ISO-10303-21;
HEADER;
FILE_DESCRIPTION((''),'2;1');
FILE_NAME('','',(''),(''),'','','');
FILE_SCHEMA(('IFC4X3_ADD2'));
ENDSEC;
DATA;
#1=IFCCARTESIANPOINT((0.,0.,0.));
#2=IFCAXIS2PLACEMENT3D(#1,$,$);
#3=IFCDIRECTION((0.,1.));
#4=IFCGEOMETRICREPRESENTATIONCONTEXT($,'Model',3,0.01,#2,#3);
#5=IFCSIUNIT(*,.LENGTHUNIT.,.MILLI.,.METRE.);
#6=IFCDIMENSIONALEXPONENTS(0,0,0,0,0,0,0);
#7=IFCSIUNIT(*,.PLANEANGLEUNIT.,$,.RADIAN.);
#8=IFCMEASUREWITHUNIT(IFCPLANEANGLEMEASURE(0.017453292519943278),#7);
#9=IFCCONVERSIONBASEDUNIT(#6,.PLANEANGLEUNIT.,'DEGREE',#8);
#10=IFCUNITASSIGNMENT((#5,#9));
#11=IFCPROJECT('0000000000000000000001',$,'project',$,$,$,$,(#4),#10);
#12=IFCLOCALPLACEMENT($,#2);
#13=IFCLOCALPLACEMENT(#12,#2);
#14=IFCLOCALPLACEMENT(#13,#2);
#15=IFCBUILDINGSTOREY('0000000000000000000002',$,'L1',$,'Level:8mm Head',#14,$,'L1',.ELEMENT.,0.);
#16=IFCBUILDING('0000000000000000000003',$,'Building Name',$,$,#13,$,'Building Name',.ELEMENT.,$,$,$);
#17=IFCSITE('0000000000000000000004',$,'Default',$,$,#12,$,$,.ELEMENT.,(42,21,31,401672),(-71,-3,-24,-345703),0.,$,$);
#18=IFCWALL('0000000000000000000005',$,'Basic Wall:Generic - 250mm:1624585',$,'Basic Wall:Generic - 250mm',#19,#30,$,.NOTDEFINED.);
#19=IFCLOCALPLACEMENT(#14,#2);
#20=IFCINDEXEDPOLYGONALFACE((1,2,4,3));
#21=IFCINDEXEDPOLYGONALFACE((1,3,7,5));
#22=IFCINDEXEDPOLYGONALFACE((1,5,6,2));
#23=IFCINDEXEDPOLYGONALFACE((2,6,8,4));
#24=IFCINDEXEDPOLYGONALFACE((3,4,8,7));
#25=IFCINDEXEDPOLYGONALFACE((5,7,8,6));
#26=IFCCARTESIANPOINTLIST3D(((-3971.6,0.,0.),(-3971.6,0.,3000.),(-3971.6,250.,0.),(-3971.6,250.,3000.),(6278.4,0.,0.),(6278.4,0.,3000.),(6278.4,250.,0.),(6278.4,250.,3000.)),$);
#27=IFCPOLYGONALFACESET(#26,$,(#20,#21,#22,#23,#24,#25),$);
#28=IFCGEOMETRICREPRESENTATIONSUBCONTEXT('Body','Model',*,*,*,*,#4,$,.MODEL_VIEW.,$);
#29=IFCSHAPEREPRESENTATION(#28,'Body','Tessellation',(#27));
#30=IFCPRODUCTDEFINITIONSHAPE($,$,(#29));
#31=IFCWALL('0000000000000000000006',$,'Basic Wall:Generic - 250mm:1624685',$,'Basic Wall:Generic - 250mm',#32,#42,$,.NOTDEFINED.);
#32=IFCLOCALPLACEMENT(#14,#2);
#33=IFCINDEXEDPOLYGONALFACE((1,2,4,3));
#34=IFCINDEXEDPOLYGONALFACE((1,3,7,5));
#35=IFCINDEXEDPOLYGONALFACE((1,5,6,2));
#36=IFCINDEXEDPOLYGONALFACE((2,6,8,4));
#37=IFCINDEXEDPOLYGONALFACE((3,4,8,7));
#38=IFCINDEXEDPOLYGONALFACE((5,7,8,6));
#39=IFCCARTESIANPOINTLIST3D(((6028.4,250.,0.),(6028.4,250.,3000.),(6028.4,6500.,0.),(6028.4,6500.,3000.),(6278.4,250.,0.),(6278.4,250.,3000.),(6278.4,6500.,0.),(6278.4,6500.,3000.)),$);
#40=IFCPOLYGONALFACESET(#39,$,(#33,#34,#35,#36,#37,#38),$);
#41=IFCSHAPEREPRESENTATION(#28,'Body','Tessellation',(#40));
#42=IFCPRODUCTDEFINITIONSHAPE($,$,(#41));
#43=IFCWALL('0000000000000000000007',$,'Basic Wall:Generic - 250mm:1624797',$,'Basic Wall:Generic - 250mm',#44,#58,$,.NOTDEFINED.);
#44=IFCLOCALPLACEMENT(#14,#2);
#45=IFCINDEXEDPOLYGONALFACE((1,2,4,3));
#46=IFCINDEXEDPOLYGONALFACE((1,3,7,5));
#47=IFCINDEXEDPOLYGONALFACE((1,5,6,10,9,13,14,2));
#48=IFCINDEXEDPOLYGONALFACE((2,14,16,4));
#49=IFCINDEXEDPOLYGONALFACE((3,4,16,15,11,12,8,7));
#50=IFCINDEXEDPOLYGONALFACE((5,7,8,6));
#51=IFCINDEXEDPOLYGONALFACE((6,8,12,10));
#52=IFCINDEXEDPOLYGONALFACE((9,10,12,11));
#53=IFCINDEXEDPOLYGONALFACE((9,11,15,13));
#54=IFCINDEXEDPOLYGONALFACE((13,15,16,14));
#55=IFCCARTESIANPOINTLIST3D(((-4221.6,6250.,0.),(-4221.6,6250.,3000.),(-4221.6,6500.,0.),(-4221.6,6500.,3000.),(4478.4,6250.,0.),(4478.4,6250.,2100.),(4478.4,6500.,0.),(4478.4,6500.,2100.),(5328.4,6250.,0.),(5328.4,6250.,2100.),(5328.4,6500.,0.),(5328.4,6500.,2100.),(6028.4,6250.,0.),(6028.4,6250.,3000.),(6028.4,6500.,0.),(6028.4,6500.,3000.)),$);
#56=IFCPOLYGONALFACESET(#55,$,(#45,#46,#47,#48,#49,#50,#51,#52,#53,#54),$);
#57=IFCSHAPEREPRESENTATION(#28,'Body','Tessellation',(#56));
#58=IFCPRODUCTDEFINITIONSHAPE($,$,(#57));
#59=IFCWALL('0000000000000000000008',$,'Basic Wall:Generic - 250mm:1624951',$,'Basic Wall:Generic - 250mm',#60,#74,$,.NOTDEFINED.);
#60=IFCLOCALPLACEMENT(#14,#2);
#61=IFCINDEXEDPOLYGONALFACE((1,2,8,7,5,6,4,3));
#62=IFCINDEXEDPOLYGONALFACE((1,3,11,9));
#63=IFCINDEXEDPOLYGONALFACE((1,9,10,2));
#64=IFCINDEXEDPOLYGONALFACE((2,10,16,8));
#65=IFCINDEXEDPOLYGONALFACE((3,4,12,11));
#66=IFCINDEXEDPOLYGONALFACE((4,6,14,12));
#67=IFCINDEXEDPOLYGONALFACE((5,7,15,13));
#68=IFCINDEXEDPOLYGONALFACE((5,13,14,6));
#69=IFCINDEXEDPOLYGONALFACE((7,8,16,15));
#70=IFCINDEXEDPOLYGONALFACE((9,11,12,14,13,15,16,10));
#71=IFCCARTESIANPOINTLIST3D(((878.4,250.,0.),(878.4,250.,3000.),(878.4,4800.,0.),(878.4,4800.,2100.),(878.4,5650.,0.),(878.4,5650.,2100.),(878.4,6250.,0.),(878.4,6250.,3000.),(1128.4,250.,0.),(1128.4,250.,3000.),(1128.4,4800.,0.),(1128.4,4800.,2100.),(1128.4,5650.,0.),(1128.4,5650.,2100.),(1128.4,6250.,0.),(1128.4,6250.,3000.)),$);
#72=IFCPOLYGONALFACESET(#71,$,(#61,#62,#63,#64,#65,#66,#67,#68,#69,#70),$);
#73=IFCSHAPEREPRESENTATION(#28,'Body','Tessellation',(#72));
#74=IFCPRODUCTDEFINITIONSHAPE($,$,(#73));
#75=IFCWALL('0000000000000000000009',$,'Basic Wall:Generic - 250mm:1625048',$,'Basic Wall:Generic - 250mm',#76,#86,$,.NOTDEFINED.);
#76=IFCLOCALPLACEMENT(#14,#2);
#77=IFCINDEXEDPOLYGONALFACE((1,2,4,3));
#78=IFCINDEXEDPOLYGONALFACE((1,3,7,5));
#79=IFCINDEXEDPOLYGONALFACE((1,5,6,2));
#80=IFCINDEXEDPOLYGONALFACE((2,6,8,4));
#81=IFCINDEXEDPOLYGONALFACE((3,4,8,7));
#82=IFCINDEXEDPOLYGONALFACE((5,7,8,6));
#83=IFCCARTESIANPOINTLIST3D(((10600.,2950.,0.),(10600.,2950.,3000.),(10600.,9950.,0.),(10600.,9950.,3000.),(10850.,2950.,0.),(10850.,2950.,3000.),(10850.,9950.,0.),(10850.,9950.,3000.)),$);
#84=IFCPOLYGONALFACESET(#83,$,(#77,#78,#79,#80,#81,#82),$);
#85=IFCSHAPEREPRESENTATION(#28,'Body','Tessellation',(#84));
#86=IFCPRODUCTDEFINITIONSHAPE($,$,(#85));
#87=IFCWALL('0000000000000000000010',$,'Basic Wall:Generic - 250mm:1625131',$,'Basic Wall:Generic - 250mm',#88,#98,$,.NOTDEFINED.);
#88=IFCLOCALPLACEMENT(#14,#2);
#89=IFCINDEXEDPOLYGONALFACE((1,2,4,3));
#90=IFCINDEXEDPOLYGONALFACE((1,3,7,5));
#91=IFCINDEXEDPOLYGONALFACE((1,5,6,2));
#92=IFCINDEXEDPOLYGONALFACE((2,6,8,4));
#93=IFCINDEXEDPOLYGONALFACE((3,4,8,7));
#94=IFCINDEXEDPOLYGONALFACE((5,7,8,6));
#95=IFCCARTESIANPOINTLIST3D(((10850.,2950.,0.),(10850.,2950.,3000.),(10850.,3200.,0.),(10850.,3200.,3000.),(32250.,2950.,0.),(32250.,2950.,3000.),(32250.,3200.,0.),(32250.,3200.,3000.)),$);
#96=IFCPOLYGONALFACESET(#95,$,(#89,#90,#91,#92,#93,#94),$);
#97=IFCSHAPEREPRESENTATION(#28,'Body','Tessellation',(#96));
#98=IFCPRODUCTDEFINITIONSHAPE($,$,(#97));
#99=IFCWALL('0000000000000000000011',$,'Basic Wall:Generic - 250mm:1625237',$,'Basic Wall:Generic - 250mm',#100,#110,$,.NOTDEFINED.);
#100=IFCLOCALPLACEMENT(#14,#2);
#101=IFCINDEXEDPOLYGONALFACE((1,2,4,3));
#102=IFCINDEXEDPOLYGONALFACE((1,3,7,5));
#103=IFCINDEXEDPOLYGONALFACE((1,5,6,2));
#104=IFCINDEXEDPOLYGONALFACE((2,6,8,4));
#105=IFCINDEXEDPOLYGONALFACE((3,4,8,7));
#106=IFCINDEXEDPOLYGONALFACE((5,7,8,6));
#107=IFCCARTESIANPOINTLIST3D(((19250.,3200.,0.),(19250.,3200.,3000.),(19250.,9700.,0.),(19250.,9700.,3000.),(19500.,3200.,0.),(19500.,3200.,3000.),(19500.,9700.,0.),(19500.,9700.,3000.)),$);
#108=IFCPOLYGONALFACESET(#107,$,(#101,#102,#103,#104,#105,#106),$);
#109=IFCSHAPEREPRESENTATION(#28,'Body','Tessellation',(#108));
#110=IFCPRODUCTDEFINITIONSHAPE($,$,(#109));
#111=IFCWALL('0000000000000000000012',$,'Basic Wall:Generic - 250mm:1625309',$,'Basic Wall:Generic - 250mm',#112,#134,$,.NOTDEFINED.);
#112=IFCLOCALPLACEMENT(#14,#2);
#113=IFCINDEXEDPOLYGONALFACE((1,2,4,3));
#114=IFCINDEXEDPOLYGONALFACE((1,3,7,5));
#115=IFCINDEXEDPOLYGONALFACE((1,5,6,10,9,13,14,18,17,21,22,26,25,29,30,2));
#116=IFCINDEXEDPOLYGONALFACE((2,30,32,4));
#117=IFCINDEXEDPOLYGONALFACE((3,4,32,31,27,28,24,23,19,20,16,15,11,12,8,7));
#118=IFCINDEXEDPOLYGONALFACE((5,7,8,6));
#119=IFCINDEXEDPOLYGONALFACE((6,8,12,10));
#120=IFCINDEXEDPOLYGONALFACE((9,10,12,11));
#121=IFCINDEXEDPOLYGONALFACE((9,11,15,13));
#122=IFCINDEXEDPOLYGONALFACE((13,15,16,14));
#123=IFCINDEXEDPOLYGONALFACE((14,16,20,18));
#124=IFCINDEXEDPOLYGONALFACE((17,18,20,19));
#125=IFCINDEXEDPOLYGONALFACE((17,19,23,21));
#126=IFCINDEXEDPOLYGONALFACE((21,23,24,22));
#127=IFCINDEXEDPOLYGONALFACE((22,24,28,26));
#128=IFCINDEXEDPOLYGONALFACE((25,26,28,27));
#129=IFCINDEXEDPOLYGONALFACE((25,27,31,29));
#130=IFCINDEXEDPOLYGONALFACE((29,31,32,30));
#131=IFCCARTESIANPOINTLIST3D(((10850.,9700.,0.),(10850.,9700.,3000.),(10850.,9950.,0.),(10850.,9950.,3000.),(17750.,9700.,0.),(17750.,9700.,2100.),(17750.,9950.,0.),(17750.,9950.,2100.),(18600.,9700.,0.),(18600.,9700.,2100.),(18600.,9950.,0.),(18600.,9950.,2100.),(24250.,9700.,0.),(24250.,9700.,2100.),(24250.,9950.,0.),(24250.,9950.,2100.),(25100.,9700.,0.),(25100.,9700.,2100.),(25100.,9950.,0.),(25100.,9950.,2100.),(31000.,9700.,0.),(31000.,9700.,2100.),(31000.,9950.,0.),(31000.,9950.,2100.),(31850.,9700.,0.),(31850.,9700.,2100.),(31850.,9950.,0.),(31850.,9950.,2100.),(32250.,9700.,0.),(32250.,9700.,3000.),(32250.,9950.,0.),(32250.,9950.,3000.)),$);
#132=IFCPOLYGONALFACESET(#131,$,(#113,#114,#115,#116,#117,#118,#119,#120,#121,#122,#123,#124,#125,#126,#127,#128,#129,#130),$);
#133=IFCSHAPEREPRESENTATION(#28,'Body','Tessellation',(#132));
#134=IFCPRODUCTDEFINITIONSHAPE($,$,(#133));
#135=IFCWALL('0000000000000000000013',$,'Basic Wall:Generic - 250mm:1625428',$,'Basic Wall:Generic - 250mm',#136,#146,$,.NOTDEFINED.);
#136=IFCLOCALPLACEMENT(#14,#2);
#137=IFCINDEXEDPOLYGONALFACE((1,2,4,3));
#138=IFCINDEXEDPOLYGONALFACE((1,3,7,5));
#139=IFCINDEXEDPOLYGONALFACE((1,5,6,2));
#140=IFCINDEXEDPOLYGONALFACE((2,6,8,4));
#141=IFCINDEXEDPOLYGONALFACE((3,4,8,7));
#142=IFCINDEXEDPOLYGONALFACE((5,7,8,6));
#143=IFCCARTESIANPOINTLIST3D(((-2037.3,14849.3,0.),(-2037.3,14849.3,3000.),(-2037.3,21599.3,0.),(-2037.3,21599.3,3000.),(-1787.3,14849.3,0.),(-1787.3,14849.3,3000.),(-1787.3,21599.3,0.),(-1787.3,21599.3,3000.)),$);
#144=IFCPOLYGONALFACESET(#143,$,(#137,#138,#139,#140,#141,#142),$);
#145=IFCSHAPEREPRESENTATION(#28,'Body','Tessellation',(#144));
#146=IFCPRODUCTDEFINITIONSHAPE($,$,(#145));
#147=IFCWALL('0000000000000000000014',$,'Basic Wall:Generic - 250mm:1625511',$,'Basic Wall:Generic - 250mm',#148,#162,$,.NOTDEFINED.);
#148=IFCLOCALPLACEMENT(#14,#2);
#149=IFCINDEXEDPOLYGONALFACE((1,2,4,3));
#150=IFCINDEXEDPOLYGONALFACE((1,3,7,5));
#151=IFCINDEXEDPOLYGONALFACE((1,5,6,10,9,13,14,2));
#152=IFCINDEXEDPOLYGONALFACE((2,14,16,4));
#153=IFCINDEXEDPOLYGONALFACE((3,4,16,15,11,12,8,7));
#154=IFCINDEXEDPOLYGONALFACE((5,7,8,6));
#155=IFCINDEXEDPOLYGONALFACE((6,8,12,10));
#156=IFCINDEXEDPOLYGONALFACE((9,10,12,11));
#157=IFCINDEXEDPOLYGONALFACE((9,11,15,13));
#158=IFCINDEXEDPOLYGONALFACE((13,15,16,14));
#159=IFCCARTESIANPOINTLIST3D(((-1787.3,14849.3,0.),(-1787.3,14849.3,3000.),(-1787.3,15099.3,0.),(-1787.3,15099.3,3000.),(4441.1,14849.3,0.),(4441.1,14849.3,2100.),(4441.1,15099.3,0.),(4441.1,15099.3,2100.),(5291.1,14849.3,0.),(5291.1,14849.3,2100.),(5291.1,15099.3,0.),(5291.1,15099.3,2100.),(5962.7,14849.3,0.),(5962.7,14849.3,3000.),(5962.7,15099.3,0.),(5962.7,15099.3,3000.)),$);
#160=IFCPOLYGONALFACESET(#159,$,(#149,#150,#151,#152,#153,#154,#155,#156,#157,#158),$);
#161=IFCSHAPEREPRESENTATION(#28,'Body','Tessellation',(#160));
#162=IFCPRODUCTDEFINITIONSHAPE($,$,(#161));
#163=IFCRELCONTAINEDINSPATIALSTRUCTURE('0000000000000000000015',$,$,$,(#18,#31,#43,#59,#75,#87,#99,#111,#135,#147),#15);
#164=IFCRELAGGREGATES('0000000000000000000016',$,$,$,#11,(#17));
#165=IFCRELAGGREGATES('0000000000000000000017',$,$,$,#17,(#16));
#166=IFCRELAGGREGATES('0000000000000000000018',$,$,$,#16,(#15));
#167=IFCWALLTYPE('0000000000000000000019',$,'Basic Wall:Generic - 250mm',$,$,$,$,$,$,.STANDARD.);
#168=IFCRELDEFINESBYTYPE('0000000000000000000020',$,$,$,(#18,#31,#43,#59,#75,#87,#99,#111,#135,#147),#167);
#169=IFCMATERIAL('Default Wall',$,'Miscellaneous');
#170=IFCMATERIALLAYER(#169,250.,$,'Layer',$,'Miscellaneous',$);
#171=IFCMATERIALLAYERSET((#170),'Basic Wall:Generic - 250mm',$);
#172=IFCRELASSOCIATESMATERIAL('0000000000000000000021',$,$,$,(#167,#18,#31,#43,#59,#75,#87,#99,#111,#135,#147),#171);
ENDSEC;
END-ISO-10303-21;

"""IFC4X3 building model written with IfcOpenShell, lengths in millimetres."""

from ifc_helpers import new_model, entity, si_unit, converted_unit, direction, frame, frame_2d, origin, place, context, subcontext, project, spatial, rectangle, extrude, material, layer, layer_set, type_object, element, save


model = new_model("IFC4X3")

# Units and contexts
model_context = context("Model", 3, precision=0.01, world=origin(), true_north=direction((0.0, 1.0)))
body_context = subcontext(model_context, "Body", "Model", "MODEL_VIEW")
ifc_project = project(units=[si_unit("LENGTHUNIT", "METRE", prefix="MILLI"), converted_unit("PLANEANGLEUNIT", "DEGREE", entity("IfcPlaneAngleMeasure", 0.017453292519943278), si_unit("PLANEANGLEUNIT", "RADIAN"), dimensions=[0, 0, 0, 0, 0, 0, 0])], contexts=[model_context])

# Site, building, storey
site_placement = place(None, origin())
site = spatial("IfcSite", under=ifc_project, at=site_placement, Name="Default", CompositionType="ELEMENT", RefLatitude=(42, 21, 31, 401672), RefLongitude=(-71, -3, -24, -345703), RefElevation=0.0)
building_placement = place(site_placement, origin())
building = spatial("IfcBuilding", under=site, at=building_placement, Name="Building Name", LongName="Building Name", CompositionType="ELEMENT")
storey_placement = place(building_placement, origin())
storey = spatial("IfcBuildingStorey", under=building, at=storey_placement, Name="L1", ObjectType="Level:8mm Head", LongName="L1", CompositionType="ELEMENT", Elevation=0.0)

# Walls
ifc_material = material(Name="Default Wall", Category="Miscellaneous")
ifc_layer = layer(ifc_material, 250.0, Name="Layer", Category="Miscellaneous")
ifc_layer_set = layer_set([ifc_layer], Name="Basic Wall:Generic - 250mm")
wall_type = type_object("IfcWallType", Name="Basic Wall:Generic - 250mm", PredefinedType="STANDARD", material=ifc_layer_set)
wall_1_placement = place(storey_placement, frame((-3971.6, 125.0, 0.0)))
element("IfcWall", 1, at=wall_1_placement, inside=storey, type_object=wall_type, material=ifc_layer_set, Name="Basic Wall:Generic - 250mm:1624585", ObjectType="Basic Wall:Generic - 250mm", PredefinedType="NOTDEFINED", context=body_context, shape_type="SweptSolid", body=[
    extrude(rectangle(XDim=10250.0, YDim=250.0, at=frame_2d((5125.0, 0.0), x_axis=(-1.0, 0.0))), origin(), (0.0, 0.0, 1.0), 3000.0),
])
wall_2_placement = place(storey_placement, frame((6153.4, 250.0, 0.0), z_axis=(0.0, 0.0, 1.0), x_axis=(0.0, 1.0, 0.0)))
element("IfcWall", 2, at=wall_2_placement, inside=storey, type_object=wall_type, material=ifc_layer_set, Name="Basic Wall:Generic - 250mm:1624685", ObjectType="Basic Wall:Generic - 250mm", PredefinedType="NOTDEFINED", context=body_context, shape_type="SweptSolid", body=[
    extrude(rectangle(XDim=6250.0, YDim=250.0, at=frame_2d((3125.0, 0.0), x_axis=(-1.0, 0.0))), origin(), (0.0, 0.0, 1.0), 3000.0),
])

# Walls, openings
wall_3_placement = place(storey_placement, frame((6028.4, 6375.0, 0.0), z_axis=(0.0, 0.0, 1.0), x_axis=(-1.0, 0.0, 0.0)))
wall_3 = element("IfcWall", 3, at=wall_3_placement, inside=storey, type_object=wall_type, material=ifc_layer_set, Name="Basic Wall:Generic - 250mm:1624797", ObjectType="Basic Wall:Generic - 250mm", PredefinedType="NOTDEFINED", context=body_context, shape_type="SweptSolid", body=[
    extrude(rectangle(XDim=10250.0, YDim=250.0, at=frame_2d((5125.0, 0.0), x_axis=(1.0, 0.0))), origin(), (0.0, 0.0, 1.0), 3000.0),
])
opening_1_placement = place(wall_3_placement, frame((700.0, -125.0, 0.0)))
element("IfcOpeningElement", 4, at=opening_1_placement, cuts=wall_3, PredefinedType="OPENING", context=body_context, shape_type="SweptSolid", body=[
    extrude(rectangle(XDim=2100.0, YDim=850.0, at=frame_2d((1050.0, 425.0), x_axis=(1.0, 0.0))), frame((0.0, 0.0, 0.0), z_axis=(0.0, 1.0, 0.0), x_axis=(0.0, 0.0, 1.0)), (0.0, 0.0, 1.0), 250.0),
])
wall_4_placement = place(storey_placement, frame((1003.4, 6250.0, 0.0), z_axis=(0.0, 0.0, 1.0), x_axis=(0.0, -1.0, 0.0)))
wall_4 = element("IfcWall", 5, at=wall_4_placement, inside=storey, type_object=wall_type, material=ifc_layer_set, Name="Basic Wall:Generic - 250mm:1624951", ObjectType="Basic Wall:Generic - 250mm", PredefinedType="NOTDEFINED", context=body_context, shape_type="SweptSolid", body=[
    extrude(rectangle(XDim=6000.0, YDim=250.0, at=frame_2d((3000.0, 0.0), x_axis=(1.0, 0.0))), origin(), (0.0, 0.0, 1.0), 3000.0),
])
opening_2_placement = place(wall_4_placement, frame((1450.0, 125.0, 0.0)))
element("IfcOpeningElement", 6, at=opening_2_placement, cuts=wall_4, PredefinedType="OPENING", context=body_context, shape_type="SweptSolid", body=[
    extrude(rectangle(XDim=2100.0, YDim=850.0, at=frame_2d((1050.0, 425.0), x_axis=(1.0, 0.0))), frame((0.0, 0.0, 0.0), z_axis=(0.0, -1.0, 0.0), x_axis=(0.0, 0.0, 1.0)), (0.0, 0.0, 1.0), 250.0),
])

# Walls
wall_5_placement = place(storey_placement, frame((10725.0, 9950.0, 0.0), z_axis=(0.0, 0.0, 1.0), x_axis=(0.0, -1.0, 0.0)))
element("IfcWall", 7, at=wall_5_placement, inside=storey, type_object=wall_type, material=ifc_layer_set, Name="Basic Wall:Generic - 250mm:1625048", ObjectType="Basic Wall:Generic - 250mm", PredefinedType="NOTDEFINED", context=body_context, shape_type="SweptSolid", body=[
    extrude(rectangle(XDim=7000.0, YDim=250.0, at=frame_2d((3500.0, 0.0), x_axis=(-1.0, 0.0))), origin(), (0.0, 0.0, 1.0), 3000.0),
])
wall_6_placement = place(storey_placement, frame((10850.0, 3075.0, 0.0)))
element("IfcWall", 8, at=wall_6_placement, inside=storey, type_object=wall_type, material=ifc_layer_set, Name="Basic Wall:Generic - 250mm:1625131", ObjectType="Basic Wall:Generic - 250mm", PredefinedType="NOTDEFINED", context=body_context, shape_type="SweptSolid", body=[
    extrude(rectangle(XDim=21400.0, YDim=250.0, at=frame_2d((10700.0, 0.0), x_axis=(-1.0, 0.0))), origin(), (0.0, 0.0, 1.0), 3000.0),
])
wall_7_placement = place(storey_placement, frame((19375.0, 3200.0, 0.0), z_axis=(0.0, 0.0, 1.0), x_axis=(0.0, 1.0, 0.0)))
element("IfcWall", 9, at=wall_7_placement, inside=storey, type_object=wall_type, material=ifc_layer_set, Name="Basic Wall:Generic - 250mm:1625237", ObjectType="Basic Wall:Generic - 250mm", PredefinedType="NOTDEFINED", context=body_context, shape_type="SweptSolid", body=[
    extrude(rectangle(XDim=6500.0, YDim=250.0, at=frame_2d((3250.0, 0.0), x_axis=(-1.0, 0.0))), origin(), (0.0, 0.0, 1.0), 3000.0),
])

# Wall, openings
wall_8_placement = place(storey_placement, frame((32250.0, 9825.0, 0.0), z_axis=(0.0, 0.0, 1.0), x_axis=(-1.0, 0.0, 0.0)))
wall_8 = element("IfcWall", 10, at=wall_8_placement, inside=storey, type_object=wall_type, material=ifc_layer_set, Name="Basic Wall:Generic - 250mm:1625309", ObjectType="Basic Wall:Generic - 250mm", PredefinedType="NOTDEFINED", context=body_context, shape_type="SweptSolid", body=[
    extrude(rectangle(XDim=21400.0, YDim=250.0, at=frame_2d((10700.0, 0.0), x_axis=(1.0, 0.0))), origin(), (0.0, 0.0, 1.0), 3000.0),
])
opening_3_placement = place(wall_8_placement, frame((13650.0, -125.0, 0.0)))
element("IfcOpeningElement", 11, at=opening_3_placement, cuts=wall_8, PredefinedType="OPENING", context=body_context, shape_type="SweptSolid", body=[
    extrude(rectangle(XDim=2100.0, YDim=850.0, at=frame_2d((1050.0, 425.0), x_axis=(1.0, 0.0))), frame((0.0, 0.0, 0.0), z_axis=(0.0, 1.0, 0.0), x_axis=(0.0, 0.0, 1.0)), (0.0, 0.0, 1.0), 250.0),
])
opening_4_placement = place(wall_8_placement, frame((7150.0, -125.0, 0.0)))
element("IfcOpeningElement", 12, at=opening_4_placement, cuts=wall_8, PredefinedType="OPENING", context=body_context, shape_type="SweptSolid", body=[
    extrude(rectangle(XDim=2100.0, YDim=850.0, at=frame_2d((1050.0, 425.0), x_axis=(1.0, 0.0))), frame((0.0, 0.0, 0.0), z_axis=(0.0, 1.0, 0.0), x_axis=(0.0, 0.0, 1.0)), (0.0, 0.0, 1.0), 250.0),
])
opening_5_placement = place(wall_8_placement, frame((400.0, -125.0, 0.0)))
element("IfcOpeningElement", 13, at=opening_5_placement, cuts=wall_8, PredefinedType="OPENING", context=body_context, shape_type="SweptSolid", body=[
    extrude(rectangle(XDim=2100.0, YDim=850.0, at=frame_2d((1050.0, 425.0), x_axis=(1.0, 0.0))), frame((0.0, 0.0, 0.0), z_axis=(0.0, 1.0, 0.0), x_axis=(0.0, 0.0, 1.0)), (0.0, 0.0, 1.0), 250.0),
])

# Wall
wall_9_placement = place(storey_placement, frame((-1912.3, 21599.3, 0.0), z_axis=(0.0, 0.0, 1.0), x_axis=(0.0, -1.0, 0.0)))
element("IfcWall", 14, at=wall_9_placement, inside=storey, type_object=wall_type, material=ifc_layer_set, Name="Basic Wall:Generic - 250mm:1625428", ObjectType="Basic Wall:Generic - 250mm", PredefinedType="NOTDEFINED", context=body_context, shape_type="SweptSolid", body=[
    extrude(rectangle(XDim=6750.0, YDim=250.0, at=frame_2d((3375.0, 0.0), x_axis=(-1.0, 0.0))), origin(), (0.0, 0.0, 1.0), 3000.0),
])

# Wall, opening
wall_10_placement = place(storey_placement, frame((-1787.3, 14974.3, 0.0)))
wall_10 = element("IfcWall", 15, at=wall_10_placement, inside=storey, type_object=wall_type, material=ifc_layer_set, Name="Basic Wall:Generic - 250mm:1625511", ObjectType="Basic Wall:Generic - 250mm", PredefinedType="NOTDEFINED", context=body_context, shape_type="SweptSolid", body=[
    extrude(rectangle(XDim=7750.0, YDim=250.0, at=frame_2d((3875.0, 0.0), x_axis=(1.0, 0.0))), origin(), (0.0, 0.0, 1.0), 3000.0),
])
opening_6_placement = place(wall_10_placement, frame((6228.4, -125.0, 0.0)))
element("IfcOpeningElement", 16, at=opening_6_placement, cuts=wall_10, PredefinedType="OPENING", context=body_context, shape_type="SweptSolid", body=[
    extrude(rectangle(XDim=2100.0, YDim=850.0, at=frame_2d((1050.0, 425.0), x_axis=(1.0, 0.0))), frame((0.0, 0.0, 0.0), z_axis=(0.0, 1.0, 0.0), x_axis=(0.0, 0.0, 1.0)), (0.0, 0.0, 1.0), 250.0),
])

save(model, "model.ifc")
